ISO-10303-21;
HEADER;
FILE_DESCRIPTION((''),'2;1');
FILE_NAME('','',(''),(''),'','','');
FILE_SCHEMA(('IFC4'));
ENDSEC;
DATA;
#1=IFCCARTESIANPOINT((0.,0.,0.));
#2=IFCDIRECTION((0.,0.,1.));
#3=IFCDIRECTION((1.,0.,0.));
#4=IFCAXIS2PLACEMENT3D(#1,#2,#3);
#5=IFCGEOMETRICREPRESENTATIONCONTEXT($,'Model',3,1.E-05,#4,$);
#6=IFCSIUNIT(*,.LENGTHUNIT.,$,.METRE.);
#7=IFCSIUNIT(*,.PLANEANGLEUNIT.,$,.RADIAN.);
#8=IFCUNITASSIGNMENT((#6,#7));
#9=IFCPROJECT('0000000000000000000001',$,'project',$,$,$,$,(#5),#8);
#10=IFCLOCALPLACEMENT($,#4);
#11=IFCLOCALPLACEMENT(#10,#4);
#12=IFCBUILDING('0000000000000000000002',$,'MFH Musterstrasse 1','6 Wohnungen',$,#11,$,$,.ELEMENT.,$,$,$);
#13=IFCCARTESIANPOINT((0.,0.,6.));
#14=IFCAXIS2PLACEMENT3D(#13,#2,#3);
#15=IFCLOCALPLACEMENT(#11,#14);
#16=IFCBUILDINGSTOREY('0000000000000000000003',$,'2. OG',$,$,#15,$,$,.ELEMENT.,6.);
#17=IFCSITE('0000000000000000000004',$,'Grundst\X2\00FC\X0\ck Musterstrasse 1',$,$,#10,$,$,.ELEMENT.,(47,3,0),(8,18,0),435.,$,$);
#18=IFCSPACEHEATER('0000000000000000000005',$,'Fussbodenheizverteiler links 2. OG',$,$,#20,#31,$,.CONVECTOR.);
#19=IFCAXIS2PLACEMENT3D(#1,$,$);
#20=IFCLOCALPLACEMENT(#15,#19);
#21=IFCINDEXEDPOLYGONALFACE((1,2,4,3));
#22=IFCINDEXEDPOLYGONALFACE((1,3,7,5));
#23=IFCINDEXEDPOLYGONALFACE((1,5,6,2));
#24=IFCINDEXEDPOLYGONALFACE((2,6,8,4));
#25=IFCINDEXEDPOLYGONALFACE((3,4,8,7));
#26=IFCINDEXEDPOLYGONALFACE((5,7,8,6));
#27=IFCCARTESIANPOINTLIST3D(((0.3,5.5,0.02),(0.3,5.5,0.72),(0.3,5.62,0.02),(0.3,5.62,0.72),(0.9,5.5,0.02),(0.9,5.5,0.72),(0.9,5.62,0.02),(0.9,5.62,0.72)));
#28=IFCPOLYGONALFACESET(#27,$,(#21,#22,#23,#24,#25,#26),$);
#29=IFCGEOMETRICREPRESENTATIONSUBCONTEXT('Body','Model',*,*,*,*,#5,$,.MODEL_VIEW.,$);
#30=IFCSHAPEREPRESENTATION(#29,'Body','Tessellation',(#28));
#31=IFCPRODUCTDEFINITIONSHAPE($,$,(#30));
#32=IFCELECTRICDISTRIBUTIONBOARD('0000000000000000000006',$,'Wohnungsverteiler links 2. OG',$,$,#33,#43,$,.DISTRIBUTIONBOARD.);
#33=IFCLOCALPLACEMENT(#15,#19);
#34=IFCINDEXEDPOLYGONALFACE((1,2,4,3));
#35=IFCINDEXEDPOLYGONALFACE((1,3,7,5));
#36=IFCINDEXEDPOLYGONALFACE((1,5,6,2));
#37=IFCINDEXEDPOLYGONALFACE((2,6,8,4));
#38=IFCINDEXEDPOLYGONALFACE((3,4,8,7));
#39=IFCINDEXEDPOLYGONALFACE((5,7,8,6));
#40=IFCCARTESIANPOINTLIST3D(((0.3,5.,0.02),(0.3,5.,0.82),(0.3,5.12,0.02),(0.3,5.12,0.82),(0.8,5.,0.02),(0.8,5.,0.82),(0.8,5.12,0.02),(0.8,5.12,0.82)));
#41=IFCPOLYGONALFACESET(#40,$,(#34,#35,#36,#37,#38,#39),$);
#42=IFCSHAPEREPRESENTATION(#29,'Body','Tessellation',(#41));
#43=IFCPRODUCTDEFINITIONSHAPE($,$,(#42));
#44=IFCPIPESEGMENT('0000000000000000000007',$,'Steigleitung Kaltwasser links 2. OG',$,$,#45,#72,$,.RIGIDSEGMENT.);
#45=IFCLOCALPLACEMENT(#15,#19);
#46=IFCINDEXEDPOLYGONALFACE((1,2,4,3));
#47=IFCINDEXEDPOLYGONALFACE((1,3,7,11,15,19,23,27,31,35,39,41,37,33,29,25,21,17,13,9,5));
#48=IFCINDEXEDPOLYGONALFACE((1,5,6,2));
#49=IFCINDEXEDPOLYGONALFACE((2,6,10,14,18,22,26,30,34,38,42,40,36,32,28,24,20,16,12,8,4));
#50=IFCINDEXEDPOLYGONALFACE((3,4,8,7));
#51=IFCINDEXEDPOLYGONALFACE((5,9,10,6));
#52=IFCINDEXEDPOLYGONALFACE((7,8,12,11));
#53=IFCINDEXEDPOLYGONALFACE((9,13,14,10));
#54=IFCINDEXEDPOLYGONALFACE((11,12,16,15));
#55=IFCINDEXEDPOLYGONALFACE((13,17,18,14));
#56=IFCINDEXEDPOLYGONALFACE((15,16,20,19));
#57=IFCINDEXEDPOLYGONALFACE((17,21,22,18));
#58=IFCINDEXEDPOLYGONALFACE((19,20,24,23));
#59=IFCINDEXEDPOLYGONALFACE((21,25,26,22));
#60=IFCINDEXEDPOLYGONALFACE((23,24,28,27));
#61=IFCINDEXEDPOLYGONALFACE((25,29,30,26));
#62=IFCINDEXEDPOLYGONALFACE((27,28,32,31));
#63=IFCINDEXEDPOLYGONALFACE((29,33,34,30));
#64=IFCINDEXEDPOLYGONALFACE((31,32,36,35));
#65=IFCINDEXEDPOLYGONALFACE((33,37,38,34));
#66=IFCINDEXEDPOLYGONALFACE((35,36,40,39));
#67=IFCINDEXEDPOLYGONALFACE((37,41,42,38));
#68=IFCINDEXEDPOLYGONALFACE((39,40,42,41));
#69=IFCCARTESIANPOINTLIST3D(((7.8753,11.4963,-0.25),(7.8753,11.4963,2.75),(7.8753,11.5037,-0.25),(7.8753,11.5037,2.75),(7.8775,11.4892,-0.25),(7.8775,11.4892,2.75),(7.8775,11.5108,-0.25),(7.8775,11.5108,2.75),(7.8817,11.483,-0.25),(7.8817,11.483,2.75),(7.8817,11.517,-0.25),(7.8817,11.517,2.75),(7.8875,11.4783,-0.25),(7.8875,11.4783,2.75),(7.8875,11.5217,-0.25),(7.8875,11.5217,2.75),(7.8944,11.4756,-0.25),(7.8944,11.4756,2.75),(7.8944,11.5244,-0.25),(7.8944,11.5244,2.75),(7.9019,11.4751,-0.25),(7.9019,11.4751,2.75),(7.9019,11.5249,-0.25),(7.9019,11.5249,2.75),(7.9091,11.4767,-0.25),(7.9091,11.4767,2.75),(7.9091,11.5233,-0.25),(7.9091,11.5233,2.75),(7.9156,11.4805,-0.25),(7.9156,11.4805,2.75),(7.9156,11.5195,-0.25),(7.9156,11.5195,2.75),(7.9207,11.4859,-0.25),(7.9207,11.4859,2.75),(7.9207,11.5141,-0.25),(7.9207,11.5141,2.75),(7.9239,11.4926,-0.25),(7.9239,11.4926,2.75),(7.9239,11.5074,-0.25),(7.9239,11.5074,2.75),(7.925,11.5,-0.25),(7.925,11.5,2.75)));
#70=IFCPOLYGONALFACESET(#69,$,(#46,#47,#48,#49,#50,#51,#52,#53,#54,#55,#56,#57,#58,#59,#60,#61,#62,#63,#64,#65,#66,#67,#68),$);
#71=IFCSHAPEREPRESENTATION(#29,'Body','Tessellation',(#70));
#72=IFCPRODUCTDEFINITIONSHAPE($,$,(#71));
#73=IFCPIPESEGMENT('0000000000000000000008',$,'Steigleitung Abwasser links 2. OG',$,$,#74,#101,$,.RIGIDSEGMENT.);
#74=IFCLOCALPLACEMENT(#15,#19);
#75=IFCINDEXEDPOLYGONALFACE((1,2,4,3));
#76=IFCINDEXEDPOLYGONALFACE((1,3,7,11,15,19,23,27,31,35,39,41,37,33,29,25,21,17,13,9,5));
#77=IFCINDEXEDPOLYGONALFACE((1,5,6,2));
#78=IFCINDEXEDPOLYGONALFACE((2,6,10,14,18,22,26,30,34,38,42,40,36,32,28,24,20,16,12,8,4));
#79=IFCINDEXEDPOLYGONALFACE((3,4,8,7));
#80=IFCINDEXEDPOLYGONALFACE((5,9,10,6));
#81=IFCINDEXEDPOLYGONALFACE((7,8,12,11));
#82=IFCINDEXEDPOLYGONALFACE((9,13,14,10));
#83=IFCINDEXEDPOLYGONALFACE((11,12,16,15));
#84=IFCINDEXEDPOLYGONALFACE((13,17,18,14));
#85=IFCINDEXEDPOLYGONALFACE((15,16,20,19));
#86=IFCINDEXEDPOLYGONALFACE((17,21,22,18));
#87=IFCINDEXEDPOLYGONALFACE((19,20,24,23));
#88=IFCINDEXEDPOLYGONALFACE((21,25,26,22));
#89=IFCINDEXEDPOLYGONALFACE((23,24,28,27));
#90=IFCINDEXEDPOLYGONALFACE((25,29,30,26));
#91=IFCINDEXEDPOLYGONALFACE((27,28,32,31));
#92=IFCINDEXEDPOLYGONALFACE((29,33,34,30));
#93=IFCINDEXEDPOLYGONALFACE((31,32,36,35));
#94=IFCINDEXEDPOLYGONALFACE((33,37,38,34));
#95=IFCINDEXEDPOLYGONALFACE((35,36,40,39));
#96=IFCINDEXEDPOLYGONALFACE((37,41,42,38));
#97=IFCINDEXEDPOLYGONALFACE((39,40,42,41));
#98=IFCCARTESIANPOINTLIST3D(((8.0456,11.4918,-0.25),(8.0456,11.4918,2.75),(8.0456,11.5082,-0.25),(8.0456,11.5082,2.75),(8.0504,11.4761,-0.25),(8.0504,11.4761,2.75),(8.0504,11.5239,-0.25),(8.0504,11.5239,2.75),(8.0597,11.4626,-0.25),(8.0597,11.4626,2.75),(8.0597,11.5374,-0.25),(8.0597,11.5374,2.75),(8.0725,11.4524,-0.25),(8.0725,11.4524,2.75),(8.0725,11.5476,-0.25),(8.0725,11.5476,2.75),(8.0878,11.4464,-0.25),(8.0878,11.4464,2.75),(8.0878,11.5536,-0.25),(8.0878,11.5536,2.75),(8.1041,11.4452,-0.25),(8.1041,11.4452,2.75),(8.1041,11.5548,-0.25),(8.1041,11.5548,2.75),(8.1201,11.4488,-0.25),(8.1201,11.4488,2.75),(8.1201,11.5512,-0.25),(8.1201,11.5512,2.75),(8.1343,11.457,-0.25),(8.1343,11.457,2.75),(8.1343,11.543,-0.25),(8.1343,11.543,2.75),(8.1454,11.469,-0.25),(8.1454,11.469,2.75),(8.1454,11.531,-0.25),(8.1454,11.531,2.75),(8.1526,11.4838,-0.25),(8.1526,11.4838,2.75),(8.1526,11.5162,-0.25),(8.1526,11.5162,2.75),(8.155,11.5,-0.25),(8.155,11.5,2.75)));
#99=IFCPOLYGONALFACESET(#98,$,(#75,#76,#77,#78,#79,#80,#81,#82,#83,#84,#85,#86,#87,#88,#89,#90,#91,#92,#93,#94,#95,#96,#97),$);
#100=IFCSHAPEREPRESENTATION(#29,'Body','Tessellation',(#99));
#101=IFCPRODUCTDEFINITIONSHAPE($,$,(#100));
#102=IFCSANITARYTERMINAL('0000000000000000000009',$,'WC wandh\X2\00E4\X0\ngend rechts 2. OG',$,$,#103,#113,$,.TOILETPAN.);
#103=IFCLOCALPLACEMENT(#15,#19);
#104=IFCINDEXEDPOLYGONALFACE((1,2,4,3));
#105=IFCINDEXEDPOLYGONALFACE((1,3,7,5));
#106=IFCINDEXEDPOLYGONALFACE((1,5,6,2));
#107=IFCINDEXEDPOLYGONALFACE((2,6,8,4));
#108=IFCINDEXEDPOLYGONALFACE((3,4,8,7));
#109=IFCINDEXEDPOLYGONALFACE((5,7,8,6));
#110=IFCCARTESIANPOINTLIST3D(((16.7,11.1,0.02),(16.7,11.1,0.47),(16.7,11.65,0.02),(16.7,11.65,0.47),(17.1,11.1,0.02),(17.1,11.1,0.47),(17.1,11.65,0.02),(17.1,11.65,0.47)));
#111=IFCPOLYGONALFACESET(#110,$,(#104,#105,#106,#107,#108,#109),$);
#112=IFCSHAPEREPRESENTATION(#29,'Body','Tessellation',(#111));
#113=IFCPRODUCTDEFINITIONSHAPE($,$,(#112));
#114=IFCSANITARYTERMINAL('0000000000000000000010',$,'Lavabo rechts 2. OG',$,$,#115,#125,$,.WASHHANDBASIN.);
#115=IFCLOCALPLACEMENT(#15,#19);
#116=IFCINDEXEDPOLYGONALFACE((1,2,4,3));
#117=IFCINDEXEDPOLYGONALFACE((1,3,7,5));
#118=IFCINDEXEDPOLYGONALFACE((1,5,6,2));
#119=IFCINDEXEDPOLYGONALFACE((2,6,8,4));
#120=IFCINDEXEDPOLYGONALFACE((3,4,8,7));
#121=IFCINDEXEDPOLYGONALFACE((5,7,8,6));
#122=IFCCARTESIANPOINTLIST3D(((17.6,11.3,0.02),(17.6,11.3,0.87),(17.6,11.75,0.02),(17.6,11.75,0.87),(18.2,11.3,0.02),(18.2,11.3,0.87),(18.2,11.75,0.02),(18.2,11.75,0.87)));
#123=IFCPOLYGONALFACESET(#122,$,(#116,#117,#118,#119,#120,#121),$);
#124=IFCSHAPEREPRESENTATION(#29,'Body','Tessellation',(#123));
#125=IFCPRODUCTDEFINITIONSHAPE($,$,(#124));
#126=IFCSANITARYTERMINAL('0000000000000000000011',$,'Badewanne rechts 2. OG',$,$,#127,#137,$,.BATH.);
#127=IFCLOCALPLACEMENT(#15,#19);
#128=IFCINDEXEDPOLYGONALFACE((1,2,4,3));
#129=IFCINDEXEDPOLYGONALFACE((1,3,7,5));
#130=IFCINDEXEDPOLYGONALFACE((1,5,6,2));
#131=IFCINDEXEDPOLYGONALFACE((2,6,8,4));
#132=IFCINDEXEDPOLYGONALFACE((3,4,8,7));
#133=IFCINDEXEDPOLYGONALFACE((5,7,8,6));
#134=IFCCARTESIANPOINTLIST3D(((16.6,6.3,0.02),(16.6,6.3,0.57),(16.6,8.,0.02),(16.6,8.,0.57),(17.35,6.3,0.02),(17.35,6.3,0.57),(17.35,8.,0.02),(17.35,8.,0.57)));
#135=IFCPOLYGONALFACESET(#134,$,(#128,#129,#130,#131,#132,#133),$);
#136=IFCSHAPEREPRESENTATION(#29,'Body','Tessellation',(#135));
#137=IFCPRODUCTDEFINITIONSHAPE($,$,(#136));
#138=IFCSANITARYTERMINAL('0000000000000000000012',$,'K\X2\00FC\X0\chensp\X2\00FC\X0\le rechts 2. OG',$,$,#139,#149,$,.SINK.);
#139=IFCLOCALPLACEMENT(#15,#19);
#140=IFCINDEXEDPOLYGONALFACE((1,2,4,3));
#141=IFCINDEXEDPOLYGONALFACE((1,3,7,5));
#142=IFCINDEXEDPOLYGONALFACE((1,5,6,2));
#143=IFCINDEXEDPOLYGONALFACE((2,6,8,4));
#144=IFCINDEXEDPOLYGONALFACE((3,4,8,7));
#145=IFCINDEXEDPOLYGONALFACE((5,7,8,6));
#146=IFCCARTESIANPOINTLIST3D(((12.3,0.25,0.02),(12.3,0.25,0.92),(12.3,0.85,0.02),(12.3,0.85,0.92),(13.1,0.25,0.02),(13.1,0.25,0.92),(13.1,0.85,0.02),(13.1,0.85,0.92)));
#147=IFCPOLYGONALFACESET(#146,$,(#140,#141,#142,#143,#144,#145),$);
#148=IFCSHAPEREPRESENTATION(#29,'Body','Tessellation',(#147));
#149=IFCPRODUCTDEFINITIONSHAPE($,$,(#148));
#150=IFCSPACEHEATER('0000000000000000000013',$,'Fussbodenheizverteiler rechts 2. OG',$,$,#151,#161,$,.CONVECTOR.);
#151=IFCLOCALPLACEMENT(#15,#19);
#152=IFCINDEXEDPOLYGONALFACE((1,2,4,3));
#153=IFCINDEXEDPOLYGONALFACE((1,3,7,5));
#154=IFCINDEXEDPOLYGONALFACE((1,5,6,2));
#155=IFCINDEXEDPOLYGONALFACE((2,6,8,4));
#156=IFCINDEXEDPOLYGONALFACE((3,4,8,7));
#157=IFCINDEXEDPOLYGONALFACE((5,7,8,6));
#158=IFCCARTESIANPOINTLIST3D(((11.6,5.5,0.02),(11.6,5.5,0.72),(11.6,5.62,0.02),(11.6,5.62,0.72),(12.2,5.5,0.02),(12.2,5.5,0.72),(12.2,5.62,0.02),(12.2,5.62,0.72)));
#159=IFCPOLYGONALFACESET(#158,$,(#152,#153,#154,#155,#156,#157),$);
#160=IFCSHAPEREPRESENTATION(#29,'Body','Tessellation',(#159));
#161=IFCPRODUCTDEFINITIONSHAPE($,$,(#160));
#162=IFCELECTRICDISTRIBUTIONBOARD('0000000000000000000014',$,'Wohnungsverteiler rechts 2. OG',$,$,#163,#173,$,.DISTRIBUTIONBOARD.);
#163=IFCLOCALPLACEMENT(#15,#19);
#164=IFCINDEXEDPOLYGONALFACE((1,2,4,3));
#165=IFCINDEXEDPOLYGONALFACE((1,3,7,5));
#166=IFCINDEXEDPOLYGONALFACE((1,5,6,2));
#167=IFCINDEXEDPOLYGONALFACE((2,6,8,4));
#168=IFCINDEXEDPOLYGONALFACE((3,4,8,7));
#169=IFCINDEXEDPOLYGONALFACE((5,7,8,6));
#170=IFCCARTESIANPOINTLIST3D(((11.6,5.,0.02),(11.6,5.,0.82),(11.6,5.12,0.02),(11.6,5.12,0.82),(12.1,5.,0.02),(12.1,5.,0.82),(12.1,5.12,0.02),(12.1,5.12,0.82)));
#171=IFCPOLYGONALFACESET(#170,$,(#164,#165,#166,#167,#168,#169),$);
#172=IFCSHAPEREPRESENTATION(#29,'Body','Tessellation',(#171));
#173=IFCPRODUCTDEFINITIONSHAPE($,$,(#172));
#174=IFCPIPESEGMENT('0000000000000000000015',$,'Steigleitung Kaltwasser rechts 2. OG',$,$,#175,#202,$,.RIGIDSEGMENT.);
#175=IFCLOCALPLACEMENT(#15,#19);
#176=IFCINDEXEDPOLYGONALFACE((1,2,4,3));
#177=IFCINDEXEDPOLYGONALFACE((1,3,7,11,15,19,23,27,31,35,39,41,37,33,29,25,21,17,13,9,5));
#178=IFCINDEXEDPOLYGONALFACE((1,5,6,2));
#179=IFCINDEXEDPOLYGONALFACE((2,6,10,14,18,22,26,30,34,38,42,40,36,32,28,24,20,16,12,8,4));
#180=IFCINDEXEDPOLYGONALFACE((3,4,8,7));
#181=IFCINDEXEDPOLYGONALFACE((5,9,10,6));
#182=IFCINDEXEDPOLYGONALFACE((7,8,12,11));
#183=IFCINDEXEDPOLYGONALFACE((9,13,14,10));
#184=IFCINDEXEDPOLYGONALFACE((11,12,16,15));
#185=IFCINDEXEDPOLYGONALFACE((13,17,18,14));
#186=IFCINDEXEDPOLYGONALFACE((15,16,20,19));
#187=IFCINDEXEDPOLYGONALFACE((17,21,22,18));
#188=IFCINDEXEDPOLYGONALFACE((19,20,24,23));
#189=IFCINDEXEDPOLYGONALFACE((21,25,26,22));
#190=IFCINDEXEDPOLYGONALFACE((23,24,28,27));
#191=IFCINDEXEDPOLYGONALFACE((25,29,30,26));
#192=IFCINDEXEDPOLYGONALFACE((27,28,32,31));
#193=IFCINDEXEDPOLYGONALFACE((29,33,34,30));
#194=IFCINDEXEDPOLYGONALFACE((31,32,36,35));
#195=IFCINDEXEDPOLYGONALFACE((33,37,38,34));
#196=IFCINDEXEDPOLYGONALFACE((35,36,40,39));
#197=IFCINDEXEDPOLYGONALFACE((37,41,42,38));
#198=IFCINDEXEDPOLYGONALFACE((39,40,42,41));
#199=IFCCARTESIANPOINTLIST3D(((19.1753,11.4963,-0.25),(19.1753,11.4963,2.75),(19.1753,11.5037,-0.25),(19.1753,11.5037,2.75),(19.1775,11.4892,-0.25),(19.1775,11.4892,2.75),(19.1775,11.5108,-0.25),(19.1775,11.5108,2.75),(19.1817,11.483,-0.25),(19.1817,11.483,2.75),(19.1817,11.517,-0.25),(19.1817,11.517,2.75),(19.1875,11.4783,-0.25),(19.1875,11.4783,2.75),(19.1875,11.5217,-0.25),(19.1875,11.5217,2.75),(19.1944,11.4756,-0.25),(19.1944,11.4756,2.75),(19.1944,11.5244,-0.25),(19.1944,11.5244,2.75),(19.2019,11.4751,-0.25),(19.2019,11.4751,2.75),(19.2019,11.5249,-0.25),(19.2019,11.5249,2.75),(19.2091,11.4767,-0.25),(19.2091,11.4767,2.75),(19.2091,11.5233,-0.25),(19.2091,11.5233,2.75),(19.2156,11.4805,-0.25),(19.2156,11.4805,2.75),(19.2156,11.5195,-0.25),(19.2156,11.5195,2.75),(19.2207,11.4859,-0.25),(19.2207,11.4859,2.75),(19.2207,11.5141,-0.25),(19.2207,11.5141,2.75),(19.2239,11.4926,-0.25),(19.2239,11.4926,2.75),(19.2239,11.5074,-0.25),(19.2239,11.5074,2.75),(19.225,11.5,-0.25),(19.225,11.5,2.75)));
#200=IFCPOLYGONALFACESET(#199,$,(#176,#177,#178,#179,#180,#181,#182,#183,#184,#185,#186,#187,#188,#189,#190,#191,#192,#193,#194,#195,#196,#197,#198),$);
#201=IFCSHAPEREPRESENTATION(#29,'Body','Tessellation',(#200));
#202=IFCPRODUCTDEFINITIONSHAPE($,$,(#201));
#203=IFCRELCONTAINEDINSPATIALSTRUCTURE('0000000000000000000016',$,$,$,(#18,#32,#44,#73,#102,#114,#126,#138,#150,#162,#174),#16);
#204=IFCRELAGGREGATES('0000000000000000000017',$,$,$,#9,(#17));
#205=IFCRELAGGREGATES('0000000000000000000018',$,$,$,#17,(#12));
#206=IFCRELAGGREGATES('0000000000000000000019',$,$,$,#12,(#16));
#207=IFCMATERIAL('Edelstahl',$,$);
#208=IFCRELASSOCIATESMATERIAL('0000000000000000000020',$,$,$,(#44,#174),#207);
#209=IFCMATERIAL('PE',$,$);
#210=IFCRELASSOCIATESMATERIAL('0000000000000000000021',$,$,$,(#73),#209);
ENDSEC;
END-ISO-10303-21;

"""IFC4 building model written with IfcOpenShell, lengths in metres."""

from ifc_helpers import new_model, si_unit, frame, frame_2d, origin_with_axes, origin_2d_with_axis, place, context, subcontext, project, spatial, rectangle, circle, extrude, material, element, save


model = new_model("IFC4")

# Units and contexts
model_context = context("Model", 3, precision=1e-05, world=origin_with_axes())
body_context = subcontext(model_context, "Body", "Model", "MODEL_VIEW")
ifc_project = project(units=[si_unit("LENGTHUNIT", "METRE"), si_unit("PLANEANGLEUNIT", "RADIAN")], contexts=[model_context])

# Site, building, storey
site_placement = place(None, origin_with_axes())
site = spatial("IfcSite", under=ifc_project, at=site_placement, Name="Grundstück Musterstrasse 1", CompositionType="ELEMENT", RefLatitude=(47, 3, 0), RefLongitude=(8, 18, 0), RefElevation=435.0)
building_placement = place(site_placement, origin_with_axes())
building = spatial("IfcBuilding", under=site, at=building_placement, Name="MFH Musterstrasse 1", Description="6 Wohnungen", CompositionType="ELEMENT")
storey_placement = place(building_placement, frame((0.0, 0.0, 6.0), z_axis=(0.0, 0.0, 1.0), x_axis=(1.0, 0.0, 0.0)))
storey = spatial("IfcBuildingStorey", under=building, at=storey_placement, Name="2. OG", CompositionType="ELEMENT", Elevation=6.0)

# Space heater
space_heater_1_placement = place(storey_placement, origin_with_axes())
element("IfcSpaceHeater", 1, at=space_heater_1_placement, inside=storey, Name="Fussbodenheizverteiler links 2. OG", PredefinedType="CONVECTOR", context=body_context, shape_type="SweptSolid", body=[
    extrude(rectangle(XDim=0.6, YDim=0.12, at=frame_2d((0.3, 0.06), x_axis=(1.0, 0.0))), frame((0.3, 5.5, 0.02), z_axis=(0.0, 0.0, 1.0), x_axis=(1.0, 0.0, 0.0)), (0.0, 0.0, 1.0), 0.7),
])

# Electric distribution board
electric_distribution_board_1_placement = place(storey_placement, origin_with_axes())
element("IfcElectricDistributionBoard", 2, at=electric_distribution_board_1_placement, inside=storey, Name="Wohnungsverteiler links 2. OG", PredefinedType="DISTRIBUTIONBOARD", context=body_context, shape_type="SweptSolid", body=[
    extrude(rectangle(XDim=0.5, YDim=0.12, at=frame_2d((0.25, 0.06), x_axis=(1.0, 0.0))), frame((0.3, 5.0, 0.02), z_axis=(0.0, 0.0, 1.0), x_axis=(1.0, 0.0, 0.0)), (0.0, 0.0, 1.0), 0.8),
])

# Pipe segments
ifc_material_1 = material(Name="Edelstahl")
pipe_segment_1_placement = place(storey_placement, origin_with_axes())
element("IfcPipeSegment", 3, at=pipe_segment_1_placement, inside=storey, material=ifc_material_1, Name="Steigleitung Kaltwasser links 2. OG", PredefinedType="RIGIDSEGMENT", context=body_context, shape_type="SweptSolid", body=[
    extrude(circle(Radius=0.025, at=origin_2d_with_axis()), frame((7.9, 11.5, -0.25), z_axis=(0.0, 0.0, 1.0), x_axis=(1.0, 0.0, 0.0)), (0.0, 0.0, 1.0), 3.0),
])
ifc_material_2 = material(Name="PE")
pipe_segment_2_placement = place(storey_placement, origin_with_axes())
element("IfcPipeSegment", 4, at=pipe_segment_2_placement, inside=storey, material=ifc_material_2, Name="Steigleitung Abwasser links 2. OG", PredefinedType="RIGIDSEGMENT", context=body_context, shape_type="SweptSolid", body=[
    extrude(circle(Radius=0.055, at=origin_2d_with_axis()), frame((8.1, 11.5, -0.25), z_axis=(0.0, 0.0, 1.0), x_axis=(1.0, 0.0, 0.0)), (0.0, 0.0, 1.0), 3.0),
])

# Sanitary terminals
sanitary_terminal_1_placement = place(storey_placement, origin_with_axes())
element("IfcSanitaryTerminal", 5, at=sanitary_terminal_1_placement, inside=storey, Name="WC wandhängend rechts 2. OG", PredefinedType="TOILETPAN", context=body_context, shape_type="SweptSolid", body=[
    extrude(rectangle(XDim=0.4, YDim=0.55, at=frame_2d((0.2, 0.275), x_axis=(1.0, 0.0))), frame((16.7, 11.1, 0.02), z_axis=(0.0, 0.0, 1.0), x_axis=(1.0, 0.0, 0.0)), (0.0, 0.0, 1.0), 0.45),
])
sanitary_terminal_2_placement = place(storey_placement, origin_with_axes())
element("IfcSanitaryTerminal", 6, at=sanitary_terminal_2_placement, inside=storey, Name="Lavabo rechts 2. OG", PredefinedType="WASHHANDBASIN", context=body_context, shape_type="SweptSolid", body=[
    extrude(rectangle(XDim=0.6, YDim=0.45, at=frame_2d((0.3, 0.225), x_axis=(1.0, 0.0))), frame((17.6, 11.3, 0.02), z_axis=(0.0, 0.0, 1.0), x_axis=(1.0, 0.0, 0.0)), (0.0, 0.0, 1.0), 0.85),
])
sanitary_terminal_3_placement = place(storey_placement, origin_with_axes())
element("IfcSanitaryTerminal", 7, at=sanitary_terminal_3_placement, inside=storey, Name="Badewanne rechts 2. OG", PredefinedType="BATH", context=body_context, shape_type="SweptSolid", body=[
    extrude(rectangle(XDim=0.75, YDim=1.7, at=frame_2d((0.375, 0.85), x_axis=(1.0, 0.0))), frame((16.6, 6.3, 0.02), z_axis=(0.0, 0.0, 1.0), x_axis=(1.0, 0.0, 0.0)), (0.0, 0.0, 1.0), 0.55),
])
sanitary_terminal_4_placement = place(storey_placement, origin_with_axes())
element("IfcSanitaryTerminal", 8, at=sanitary_terminal_4_placement, inside=storey, Name="Küchenspüle rechts 2. OG", PredefinedType="SINK", context=body_context, shape_type="SweptSolid", body=[
    extrude(rectangle(XDim=0.8, YDim=0.6, at=frame_2d((0.4, 0.3), x_axis=(1.0, 0.0))), frame((12.3, 0.25, 0.02), z_axis=(0.0, 0.0, 1.0), x_axis=(1.0, 0.0, 0.0)), (0.0, 0.0, 1.0), 0.9),
])

# Space heater
space_heater_2_placement = place(storey_placement, origin_with_axes())
element("IfcSpaceHeater", 9, at=space_heater_2_placement, inside=storey, Name="Fussbodenheizverteiler rechts 2. OG", PredefinedType="CONVECTOR", context=body_context, shape_type="SweptSolid", body=[
    extrude(rectangle(XDim=0.6, YDim=0.12, at=frame_2d((0.3, 0.06), x_axis=(1.0, 0.0))), frame((11.6, 5.5, 0.02), z_axis=(0.0, 0.0, 1.0), x_axis=(1.0, 0.0, 0.0)), (0.0, 0.0, 1.0), 0.7),
])

# Electric distribution board
electric_distribution_board_2_placement = place(storey_placement, origin_with_axes())
element("IfcElectricDistributionBoard", 10, at=electric_distribution_board_2_placement, inside=storey, Name="Wohnungsverteiler rechts 2. OG", PredefinedType="DISTRIBUTIONBOARD", context=body_context, shape_type="SweptSolid", body=[
    extrude(rectangle(XDim=0.5, YDim=0.12, at=frame_2d((0.25, 0.06), x_axis=(1.0, 0.0))), frame((11.6, 5.0, 0.02), z_axis=(0.0, 0.0, 1.0), x_axis=(1.0, 0.0, 0.0)), (0.0, 0.0, 1.0), 0.8),
])

# Pipe segment
pipe_segment_3_placement = place(storey_placement, origin_with_axes())
element("IfcPipeSegment", 11, at=pipe_segment_3_placement, inside=storey, material=ifc_material_1, Name="Steigleitung Kaltwasser rechts 2. OG", PredefinedType="RIGIDSEGMENT", context=body_context, shape_type="SweptSolid", body=[
    extrude(circle(Radius=0.025, at=origin_2d_with_axis()), frame((19.2, 11.5, -0.25), z_axis=(0.0, 0.0, 1.0), x_axis=(1.0, 0.0, 0.0)), (0.0, 0.0, 1.0), 3.0),
])

save(model, "model.ifc")
